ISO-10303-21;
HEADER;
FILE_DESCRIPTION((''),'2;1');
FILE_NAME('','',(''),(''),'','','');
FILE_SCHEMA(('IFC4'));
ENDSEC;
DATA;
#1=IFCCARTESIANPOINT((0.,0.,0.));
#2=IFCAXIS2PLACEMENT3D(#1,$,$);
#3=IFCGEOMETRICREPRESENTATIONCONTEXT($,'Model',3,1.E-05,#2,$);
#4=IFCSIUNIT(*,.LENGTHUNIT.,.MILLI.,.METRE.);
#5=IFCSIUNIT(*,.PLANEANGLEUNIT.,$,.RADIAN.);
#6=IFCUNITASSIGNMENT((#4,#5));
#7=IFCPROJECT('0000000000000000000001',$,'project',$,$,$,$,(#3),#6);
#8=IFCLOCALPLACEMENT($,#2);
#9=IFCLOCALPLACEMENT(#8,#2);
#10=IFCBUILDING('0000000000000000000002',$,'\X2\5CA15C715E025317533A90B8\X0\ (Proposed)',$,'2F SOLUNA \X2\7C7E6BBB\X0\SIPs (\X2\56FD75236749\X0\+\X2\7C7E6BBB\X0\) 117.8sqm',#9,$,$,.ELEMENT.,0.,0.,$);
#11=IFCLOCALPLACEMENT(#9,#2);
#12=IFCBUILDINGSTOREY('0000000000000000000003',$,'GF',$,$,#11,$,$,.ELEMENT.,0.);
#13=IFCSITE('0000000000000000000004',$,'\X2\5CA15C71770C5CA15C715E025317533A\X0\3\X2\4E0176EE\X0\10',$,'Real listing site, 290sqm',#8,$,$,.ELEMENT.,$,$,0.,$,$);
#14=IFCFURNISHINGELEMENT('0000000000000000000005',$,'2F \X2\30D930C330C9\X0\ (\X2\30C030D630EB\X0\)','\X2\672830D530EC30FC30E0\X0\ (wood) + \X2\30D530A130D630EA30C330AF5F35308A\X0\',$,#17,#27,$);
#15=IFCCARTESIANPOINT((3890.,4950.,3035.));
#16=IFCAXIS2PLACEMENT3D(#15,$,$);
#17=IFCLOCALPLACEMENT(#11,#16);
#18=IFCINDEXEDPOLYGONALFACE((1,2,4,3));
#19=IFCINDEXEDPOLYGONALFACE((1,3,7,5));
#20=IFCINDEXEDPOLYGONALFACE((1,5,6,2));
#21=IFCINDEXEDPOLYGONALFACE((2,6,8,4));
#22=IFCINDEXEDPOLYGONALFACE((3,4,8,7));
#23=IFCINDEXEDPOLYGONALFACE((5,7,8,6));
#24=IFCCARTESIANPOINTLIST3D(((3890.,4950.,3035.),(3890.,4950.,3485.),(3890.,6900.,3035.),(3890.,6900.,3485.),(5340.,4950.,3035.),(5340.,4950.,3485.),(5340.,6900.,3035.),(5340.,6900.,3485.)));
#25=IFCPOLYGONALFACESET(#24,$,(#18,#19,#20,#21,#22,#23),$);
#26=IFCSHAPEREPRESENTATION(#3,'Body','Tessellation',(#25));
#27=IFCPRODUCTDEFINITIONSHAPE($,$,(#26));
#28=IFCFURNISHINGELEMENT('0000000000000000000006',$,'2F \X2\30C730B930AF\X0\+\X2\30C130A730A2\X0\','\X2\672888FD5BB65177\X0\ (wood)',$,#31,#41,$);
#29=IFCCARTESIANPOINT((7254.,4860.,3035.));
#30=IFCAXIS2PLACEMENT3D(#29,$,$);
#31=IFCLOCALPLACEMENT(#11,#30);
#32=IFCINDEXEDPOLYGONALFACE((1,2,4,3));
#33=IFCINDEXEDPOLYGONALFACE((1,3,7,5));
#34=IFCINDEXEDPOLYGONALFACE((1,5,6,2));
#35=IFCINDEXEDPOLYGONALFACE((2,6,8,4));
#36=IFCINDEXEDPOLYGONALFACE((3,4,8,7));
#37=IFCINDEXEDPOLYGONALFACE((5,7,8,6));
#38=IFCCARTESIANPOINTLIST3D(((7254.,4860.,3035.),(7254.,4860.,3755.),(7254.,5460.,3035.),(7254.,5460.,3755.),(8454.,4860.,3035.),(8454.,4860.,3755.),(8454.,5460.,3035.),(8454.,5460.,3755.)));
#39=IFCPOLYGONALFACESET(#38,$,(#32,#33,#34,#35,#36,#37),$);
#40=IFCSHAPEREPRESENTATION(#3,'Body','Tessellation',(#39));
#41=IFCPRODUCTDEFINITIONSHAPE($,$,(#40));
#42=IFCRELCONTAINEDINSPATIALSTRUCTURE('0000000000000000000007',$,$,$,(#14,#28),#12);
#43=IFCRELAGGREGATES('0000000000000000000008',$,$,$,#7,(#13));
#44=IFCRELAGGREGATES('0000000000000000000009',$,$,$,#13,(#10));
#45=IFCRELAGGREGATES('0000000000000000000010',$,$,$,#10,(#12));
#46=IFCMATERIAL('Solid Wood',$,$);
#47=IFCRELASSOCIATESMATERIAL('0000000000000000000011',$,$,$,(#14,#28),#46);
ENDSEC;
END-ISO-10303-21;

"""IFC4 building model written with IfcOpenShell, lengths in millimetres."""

from ifc_helpers import new_model, si_unit, frame, frame_2d, origin, place, context, project, spatial, rectangle, extrude, material, element, save


model = new_model("IFC4")

# Units and contexts
model_context = context("Model", 3, precision=1e-05, world=origin())
ifc_project = project(units=[si_unit("LENGTHUNIT", "METRE", prefix="MILLI"), si_unit("PLANEANGLEUNIT", "RADIAN")], contexts=[model_context])

# Site, building, storey
site_placement = place(None, origin())
site = spatial("IfcSite", under=ifc_project, at=site_placement, Name="岡山県岡山市北区3丁目10", ObjectType="Real listing site, 290sqm", CompositionType="ELEMENT", RefElevation=0.0)
building_placement = place(site_placement, origin())
building = spatial("IfcBuilding", under=site, at=building_placement, Name="岡山市北区邸 (Proposed)", ObjectType="2F SOLUNA 籾殻SIPs (国産杉+籾殻) 117.8sqm", CompositionType="ELEMENT", ElevationOfRefHeight=0.0, ElevationOfTerrain=0.0)
storey_placement = place(building_placement, origin())
storey = spatial("IfcBuildingStorey", under=building, at=storey_placement, Name="GF", CompositionType="ELEMENT", Elevation=0.0)

# Shared definitions
ifc_material_1 = material(Name="Solid Wood")

# Furnishing elements
furnishing_1_placement = place(storey_placement, frame((3890.0, 4950.0, 3035.0)))
element("IfcFurnishingElement", 1, at=furnishing_1_placement, inside=storey, material=ifc_material_1, Name="2F ベッド (ダブル)", Description="木フレーム (wood) + ファブリック張り", context=model_context, shape_type="SweptSolid", body=[
    extrude(rectangle(XDim=1450.0, YDim=1950.0, at=frame_2d((725.0, 975.0))), frame((3890.0, 4950.0, 3035.0)), (0.0, 0.0, 1.0), 450.0),
])
furnishing_2_placement = place(storey_placement, frame((7254.0, 4860.0, 3035.0)))
element("IfcFurnishingElement", 2, at=furnishing_2_placement, inside=storey, material=ifc_material_1, Name="2F デスク+チェア", Description="木製家具 (wood)", context=model_context, shape_type="SweptSolid", body=[
    extrude(rectangle(XDim=1200.0, YDim=600.0, at=frame_2d((600.0, 300.0))), frame((7254.0, 4860.0, 3035.0)), (0.0, 0.0, 1.0), 720.0),
])

save(model, "model.ifc")
